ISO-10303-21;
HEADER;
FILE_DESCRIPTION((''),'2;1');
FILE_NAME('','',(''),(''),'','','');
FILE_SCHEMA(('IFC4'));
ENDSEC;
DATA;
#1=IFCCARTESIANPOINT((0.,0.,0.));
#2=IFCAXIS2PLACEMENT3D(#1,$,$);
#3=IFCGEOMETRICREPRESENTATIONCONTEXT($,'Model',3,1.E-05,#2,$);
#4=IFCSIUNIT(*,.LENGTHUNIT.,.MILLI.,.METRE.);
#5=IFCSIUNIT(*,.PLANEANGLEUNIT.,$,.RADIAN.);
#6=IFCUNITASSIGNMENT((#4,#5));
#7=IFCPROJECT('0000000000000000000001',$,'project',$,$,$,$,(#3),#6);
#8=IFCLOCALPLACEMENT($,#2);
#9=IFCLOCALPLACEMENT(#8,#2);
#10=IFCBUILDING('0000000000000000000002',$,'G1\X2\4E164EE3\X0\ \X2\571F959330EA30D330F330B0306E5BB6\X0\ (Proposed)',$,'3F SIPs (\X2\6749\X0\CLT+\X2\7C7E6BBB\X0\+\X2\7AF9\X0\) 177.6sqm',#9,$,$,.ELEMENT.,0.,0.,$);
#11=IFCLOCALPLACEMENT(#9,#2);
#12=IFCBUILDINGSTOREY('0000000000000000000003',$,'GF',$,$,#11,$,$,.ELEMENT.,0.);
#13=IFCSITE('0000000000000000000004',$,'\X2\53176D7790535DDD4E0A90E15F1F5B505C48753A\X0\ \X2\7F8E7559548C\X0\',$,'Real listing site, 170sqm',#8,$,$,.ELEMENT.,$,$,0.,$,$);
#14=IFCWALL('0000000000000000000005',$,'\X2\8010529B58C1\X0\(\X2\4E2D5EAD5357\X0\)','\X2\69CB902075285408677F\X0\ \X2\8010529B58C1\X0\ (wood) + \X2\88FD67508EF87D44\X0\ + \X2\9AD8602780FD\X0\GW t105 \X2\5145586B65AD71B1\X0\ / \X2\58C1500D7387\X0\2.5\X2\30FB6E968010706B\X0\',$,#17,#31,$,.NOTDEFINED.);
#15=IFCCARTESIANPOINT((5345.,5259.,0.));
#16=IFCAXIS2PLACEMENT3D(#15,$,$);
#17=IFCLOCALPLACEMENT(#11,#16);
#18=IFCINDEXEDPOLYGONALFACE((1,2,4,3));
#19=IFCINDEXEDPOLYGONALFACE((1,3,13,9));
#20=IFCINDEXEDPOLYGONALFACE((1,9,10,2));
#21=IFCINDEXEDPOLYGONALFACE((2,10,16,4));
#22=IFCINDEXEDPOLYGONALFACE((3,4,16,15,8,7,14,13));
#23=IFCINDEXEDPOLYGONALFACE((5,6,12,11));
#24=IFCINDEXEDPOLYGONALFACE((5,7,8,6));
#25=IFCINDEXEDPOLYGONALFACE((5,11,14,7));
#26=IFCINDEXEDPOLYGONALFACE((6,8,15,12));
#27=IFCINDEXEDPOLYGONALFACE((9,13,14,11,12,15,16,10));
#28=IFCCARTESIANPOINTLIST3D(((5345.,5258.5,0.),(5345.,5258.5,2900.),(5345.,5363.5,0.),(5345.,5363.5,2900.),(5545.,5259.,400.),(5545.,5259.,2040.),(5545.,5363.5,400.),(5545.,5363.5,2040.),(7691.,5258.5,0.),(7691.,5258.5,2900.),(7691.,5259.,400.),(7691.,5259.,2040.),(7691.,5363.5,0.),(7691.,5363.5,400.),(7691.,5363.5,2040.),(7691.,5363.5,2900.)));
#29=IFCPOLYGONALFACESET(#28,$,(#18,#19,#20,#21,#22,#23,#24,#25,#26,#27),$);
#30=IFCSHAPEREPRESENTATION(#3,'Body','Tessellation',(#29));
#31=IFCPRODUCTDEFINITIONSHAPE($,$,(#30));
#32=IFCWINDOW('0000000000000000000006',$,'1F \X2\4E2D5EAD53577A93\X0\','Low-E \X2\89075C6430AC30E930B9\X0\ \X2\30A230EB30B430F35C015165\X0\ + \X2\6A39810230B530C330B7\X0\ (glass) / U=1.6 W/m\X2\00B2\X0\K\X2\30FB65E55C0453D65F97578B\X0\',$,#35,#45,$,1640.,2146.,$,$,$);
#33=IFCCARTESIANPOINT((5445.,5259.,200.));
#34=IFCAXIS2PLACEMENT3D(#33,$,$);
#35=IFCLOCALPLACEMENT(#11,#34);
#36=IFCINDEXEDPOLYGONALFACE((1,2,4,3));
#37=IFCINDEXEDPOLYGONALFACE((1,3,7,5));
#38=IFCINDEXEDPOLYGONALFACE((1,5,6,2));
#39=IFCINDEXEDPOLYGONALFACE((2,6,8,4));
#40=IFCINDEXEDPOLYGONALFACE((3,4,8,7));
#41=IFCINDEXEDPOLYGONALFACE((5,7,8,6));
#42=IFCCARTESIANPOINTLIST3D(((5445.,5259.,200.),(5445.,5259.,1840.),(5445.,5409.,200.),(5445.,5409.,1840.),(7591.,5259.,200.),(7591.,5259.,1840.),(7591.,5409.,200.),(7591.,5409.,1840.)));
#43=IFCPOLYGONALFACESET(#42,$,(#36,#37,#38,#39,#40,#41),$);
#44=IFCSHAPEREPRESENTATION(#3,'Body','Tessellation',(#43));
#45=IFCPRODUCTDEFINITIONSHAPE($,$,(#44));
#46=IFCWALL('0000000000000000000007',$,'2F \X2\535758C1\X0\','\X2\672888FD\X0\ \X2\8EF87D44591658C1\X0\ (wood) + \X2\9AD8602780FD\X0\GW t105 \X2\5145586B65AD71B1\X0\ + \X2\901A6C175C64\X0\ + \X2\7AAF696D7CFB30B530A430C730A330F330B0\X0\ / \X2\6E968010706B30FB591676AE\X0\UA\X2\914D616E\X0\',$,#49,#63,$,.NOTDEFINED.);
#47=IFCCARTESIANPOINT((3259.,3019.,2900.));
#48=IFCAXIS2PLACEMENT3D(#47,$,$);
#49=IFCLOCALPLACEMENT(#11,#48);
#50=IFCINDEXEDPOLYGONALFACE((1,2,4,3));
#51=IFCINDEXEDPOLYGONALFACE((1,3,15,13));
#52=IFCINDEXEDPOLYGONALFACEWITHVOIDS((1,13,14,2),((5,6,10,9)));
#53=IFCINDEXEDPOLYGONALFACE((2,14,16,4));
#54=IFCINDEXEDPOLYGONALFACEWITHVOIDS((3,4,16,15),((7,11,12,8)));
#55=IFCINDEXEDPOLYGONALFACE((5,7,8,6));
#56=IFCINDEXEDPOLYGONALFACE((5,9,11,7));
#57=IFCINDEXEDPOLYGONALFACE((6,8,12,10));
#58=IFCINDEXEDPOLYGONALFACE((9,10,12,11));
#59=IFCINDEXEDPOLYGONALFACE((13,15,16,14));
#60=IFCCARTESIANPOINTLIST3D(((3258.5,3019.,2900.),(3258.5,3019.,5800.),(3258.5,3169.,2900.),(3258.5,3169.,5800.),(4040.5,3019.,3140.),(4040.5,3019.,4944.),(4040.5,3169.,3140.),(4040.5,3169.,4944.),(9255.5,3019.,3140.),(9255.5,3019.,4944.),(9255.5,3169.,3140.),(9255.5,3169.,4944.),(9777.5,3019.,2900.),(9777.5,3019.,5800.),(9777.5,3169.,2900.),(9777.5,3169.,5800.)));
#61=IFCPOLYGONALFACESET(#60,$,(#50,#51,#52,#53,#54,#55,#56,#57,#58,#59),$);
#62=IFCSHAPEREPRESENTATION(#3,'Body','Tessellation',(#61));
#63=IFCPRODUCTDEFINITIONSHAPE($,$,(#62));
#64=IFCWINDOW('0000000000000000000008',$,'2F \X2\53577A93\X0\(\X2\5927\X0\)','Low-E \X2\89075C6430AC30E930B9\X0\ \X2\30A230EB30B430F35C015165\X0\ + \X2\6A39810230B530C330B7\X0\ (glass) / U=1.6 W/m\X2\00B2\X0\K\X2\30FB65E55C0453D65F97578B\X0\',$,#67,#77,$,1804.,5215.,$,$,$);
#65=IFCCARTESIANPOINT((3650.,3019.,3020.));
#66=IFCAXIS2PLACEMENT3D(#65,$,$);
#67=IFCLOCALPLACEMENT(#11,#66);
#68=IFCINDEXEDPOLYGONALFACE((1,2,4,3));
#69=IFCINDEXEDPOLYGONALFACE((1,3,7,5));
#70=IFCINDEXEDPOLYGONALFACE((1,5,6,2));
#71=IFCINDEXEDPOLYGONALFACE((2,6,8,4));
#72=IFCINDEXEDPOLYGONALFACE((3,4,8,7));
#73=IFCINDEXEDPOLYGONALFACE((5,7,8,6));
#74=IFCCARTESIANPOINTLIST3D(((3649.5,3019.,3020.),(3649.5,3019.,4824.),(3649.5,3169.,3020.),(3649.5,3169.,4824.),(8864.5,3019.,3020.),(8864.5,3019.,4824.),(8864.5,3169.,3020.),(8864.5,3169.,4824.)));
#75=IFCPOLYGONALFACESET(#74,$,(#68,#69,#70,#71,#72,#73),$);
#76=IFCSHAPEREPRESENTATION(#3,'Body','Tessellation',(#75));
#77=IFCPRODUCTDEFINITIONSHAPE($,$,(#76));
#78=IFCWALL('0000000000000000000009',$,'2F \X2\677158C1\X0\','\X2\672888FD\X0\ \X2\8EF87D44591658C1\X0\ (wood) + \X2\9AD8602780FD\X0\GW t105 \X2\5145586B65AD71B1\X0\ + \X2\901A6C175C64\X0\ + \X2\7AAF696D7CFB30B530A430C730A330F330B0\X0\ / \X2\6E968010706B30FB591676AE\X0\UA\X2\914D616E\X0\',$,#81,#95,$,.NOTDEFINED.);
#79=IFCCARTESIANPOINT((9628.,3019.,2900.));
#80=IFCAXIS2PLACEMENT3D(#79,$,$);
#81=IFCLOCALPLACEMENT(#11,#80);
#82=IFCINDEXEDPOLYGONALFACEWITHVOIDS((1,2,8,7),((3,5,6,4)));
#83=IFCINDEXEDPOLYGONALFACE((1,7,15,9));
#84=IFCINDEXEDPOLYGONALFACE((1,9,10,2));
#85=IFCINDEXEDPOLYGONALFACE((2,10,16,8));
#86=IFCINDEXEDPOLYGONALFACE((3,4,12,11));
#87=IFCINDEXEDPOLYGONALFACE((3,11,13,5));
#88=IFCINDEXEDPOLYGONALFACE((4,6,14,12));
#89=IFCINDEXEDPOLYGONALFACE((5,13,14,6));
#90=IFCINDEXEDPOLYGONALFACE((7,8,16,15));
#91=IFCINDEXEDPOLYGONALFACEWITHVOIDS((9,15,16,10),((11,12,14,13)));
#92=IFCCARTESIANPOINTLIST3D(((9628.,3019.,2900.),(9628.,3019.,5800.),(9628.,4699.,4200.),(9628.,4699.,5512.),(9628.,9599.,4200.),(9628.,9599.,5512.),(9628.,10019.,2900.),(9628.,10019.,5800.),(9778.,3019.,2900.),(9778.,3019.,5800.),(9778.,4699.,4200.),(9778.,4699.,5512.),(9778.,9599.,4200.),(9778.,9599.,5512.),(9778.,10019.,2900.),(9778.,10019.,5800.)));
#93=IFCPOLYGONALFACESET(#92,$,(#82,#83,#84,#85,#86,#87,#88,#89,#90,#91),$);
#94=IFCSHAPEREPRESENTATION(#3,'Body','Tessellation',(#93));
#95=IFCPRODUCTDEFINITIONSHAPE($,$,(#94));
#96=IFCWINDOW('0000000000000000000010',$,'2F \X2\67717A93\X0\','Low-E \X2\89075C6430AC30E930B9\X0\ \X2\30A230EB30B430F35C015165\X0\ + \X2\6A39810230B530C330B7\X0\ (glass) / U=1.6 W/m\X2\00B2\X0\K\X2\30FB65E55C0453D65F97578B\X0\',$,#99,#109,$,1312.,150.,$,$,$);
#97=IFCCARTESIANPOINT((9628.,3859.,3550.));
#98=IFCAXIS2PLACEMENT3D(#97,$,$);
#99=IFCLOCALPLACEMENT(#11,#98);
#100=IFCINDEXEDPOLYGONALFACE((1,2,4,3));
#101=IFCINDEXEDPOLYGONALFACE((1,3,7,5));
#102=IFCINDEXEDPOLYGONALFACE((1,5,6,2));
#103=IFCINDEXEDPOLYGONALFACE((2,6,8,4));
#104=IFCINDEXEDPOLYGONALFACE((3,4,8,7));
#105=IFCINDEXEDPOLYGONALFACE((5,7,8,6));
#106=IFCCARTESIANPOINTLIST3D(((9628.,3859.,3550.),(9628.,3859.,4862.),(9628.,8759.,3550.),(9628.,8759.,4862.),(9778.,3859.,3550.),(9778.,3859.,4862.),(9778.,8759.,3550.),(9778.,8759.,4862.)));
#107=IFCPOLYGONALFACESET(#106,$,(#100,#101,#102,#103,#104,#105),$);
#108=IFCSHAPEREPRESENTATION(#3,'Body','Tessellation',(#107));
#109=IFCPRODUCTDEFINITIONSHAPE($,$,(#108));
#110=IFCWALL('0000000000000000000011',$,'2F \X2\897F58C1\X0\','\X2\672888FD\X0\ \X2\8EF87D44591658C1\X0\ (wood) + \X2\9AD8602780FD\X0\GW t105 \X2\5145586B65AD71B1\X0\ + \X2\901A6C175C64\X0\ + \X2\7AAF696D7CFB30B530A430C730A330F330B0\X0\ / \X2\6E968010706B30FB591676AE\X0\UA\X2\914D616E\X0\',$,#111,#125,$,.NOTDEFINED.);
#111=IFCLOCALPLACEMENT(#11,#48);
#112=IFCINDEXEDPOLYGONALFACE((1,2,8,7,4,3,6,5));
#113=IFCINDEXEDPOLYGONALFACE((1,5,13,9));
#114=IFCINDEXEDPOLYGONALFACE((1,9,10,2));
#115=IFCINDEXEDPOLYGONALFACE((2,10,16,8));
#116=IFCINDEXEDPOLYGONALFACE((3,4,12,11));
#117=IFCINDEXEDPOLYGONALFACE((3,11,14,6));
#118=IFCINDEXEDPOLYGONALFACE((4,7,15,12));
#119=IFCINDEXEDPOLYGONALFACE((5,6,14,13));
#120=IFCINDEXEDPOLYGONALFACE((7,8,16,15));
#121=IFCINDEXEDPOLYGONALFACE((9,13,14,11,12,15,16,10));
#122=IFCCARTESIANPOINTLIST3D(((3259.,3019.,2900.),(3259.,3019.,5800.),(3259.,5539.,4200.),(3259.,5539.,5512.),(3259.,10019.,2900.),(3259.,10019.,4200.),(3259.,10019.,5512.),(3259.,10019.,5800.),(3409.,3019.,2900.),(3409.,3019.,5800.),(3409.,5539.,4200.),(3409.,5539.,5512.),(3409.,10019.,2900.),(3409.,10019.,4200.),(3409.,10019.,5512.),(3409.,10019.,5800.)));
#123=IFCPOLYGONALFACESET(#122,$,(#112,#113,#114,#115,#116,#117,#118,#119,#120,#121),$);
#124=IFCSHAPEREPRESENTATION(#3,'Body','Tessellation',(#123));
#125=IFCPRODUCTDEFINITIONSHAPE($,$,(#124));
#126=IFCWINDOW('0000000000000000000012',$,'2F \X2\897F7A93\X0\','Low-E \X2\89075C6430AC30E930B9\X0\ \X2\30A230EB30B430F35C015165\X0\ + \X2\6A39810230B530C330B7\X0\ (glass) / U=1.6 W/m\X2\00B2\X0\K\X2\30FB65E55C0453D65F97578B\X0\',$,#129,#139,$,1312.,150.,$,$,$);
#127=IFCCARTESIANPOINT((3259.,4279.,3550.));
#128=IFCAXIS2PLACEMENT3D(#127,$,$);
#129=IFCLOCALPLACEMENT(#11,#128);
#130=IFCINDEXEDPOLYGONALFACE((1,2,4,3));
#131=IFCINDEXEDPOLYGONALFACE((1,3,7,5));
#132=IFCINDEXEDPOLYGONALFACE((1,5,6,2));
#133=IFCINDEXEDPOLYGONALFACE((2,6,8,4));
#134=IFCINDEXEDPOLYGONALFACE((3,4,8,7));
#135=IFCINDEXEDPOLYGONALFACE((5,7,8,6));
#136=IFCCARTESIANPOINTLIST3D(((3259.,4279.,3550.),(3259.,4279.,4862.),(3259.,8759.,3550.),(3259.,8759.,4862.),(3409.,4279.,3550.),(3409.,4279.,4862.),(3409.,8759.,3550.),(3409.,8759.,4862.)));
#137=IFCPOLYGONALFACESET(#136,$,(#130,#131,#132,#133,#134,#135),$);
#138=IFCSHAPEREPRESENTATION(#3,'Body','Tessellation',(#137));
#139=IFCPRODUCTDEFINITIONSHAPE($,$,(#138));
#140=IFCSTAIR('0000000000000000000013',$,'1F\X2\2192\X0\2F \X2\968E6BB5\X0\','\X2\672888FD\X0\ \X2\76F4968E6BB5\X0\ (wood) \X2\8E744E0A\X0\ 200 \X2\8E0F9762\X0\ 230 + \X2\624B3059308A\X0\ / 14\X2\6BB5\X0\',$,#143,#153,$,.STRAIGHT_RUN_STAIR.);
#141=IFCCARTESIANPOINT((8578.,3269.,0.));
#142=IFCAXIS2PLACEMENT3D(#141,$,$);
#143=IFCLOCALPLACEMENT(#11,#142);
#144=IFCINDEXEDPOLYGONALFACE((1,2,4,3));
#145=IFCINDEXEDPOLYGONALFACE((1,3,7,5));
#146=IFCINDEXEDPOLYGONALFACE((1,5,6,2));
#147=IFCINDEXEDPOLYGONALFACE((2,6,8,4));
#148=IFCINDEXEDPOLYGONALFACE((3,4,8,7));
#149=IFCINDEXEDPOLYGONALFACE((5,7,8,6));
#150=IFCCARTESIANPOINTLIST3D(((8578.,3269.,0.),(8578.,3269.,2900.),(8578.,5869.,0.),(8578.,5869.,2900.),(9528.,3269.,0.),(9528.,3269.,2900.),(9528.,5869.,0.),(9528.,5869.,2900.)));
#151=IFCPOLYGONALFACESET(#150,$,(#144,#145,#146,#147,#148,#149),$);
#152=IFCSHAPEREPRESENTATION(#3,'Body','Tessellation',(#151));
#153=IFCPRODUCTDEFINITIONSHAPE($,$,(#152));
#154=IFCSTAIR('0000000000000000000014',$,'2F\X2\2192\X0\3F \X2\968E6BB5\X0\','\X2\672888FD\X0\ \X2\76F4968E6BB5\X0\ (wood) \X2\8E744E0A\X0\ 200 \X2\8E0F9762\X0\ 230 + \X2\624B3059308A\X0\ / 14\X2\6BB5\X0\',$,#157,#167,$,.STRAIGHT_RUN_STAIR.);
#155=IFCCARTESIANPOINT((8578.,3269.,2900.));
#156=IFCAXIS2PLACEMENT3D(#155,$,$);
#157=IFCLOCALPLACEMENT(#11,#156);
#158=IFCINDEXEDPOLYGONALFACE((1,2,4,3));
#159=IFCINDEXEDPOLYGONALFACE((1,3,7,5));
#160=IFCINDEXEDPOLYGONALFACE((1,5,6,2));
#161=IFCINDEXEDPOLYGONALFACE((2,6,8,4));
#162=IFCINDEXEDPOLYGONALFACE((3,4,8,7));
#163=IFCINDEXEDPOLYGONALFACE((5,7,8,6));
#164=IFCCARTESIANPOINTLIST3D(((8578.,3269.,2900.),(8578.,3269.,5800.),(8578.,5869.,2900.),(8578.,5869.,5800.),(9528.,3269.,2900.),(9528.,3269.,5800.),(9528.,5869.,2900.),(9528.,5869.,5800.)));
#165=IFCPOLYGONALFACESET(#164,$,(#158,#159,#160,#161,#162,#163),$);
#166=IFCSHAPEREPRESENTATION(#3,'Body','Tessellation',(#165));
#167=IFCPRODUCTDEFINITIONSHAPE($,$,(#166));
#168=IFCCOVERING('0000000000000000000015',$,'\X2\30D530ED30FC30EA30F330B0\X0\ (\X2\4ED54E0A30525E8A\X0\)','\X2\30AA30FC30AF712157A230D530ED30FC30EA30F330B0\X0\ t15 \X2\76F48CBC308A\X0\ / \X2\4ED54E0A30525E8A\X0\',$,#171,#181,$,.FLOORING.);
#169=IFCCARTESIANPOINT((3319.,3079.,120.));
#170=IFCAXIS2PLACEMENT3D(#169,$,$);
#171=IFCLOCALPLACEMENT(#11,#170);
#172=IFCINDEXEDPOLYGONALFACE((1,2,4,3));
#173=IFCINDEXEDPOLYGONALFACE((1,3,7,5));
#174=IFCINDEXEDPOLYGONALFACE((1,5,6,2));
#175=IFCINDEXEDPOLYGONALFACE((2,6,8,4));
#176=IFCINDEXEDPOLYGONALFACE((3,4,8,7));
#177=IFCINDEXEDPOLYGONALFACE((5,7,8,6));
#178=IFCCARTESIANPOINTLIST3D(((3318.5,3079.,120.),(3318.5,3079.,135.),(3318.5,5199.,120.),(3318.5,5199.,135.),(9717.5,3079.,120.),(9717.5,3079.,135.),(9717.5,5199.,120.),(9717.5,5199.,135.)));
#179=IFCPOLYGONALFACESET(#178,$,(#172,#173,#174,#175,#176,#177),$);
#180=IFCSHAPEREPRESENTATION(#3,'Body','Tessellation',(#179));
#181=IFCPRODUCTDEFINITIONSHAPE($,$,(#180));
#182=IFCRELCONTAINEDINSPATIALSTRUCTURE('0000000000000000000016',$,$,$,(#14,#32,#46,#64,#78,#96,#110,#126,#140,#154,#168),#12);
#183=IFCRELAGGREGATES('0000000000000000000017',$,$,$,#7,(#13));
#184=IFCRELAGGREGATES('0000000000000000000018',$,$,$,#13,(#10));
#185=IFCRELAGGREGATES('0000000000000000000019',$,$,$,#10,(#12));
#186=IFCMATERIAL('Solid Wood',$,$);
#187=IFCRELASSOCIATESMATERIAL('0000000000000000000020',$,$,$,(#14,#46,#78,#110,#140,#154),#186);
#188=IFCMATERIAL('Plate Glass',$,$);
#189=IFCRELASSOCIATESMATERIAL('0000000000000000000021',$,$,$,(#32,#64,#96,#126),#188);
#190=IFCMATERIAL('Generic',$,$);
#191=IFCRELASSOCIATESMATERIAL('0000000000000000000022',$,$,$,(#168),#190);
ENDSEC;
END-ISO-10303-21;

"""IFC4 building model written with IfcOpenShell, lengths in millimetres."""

from ifc_helpers import new_model, si_unit, frame, frame_2d, origin, place, context, project, spatial, rectangle, extrude, material, element, fill, save


model = new_model("IFC4")

# Units and contexts
model_context = context("Model", 3, precision=1e-05, world=origin())
ifc_project = project(units=[si_unit("LENGTHUNIT", "METRE", prefix="MILLI"), si_unit("PLANEANGLEUNIT", "RADIAN")], contexts=[model_context])

# Site, building, storey
site_placement = place(None, origin())
site = spatial("IfcSite", under=ifc_project, at=site_placement, Name="北海道川上郡弟子屈町 美留和", ObjectType="Real listing site, 170sqm", CompositionType="ELEMENT", RefElevation=0.0)
building_placement = place(site_placement, origin())
building = spatial("IfcBuilding", under=site, at=building_placement, Name="G1世代 土間リビングの家 (Proposed)", ObjectType="3F SIPs (杉CLT+籾殻+竹) 177.6sqm", CompositionType="ELEMENT", ElevationOfRefHeight=0.0, ElevationOfTerrain=0.0)
storey_placement = place(building_placement, origin())
storey = spatial("IfcBuildingStorey", under=building, at=storey_placement, Name="GF", CompositionType="ELEMENT", Elevation=0.0)

# Shared definitions
ifc_material_1 = material(Name="Solid Wood")
ifc_material_2 = material(Name="Generic")

# Shared definitions
ifc_material_3 = material(Name="Plate Glass")

# Walls, openings, windows
wall_1_placement = place(storey_placement, frame((5345.0, 5259.0, 0.0)))
wall_1 = element("IfcWall", 1, at=wall_1_placement, inside=storey, material=ifc_material_1, Name="耐力壁(中庭南)", Description="構造用合板 耐力壁 (wood) + 製材軸組 + 高性能GW t105 充填断熱 / 壁倍率2.5・準耐火", PredefinedType="NOTDEFINED", context=model_context, shape_type="SweptSolid", body=[
    extrude(rectangle(XDim=2346.0, YDim=105.0, at=frame_2d((1173.0, 52.0))), frame((5345.0, 5259.0, 0.0)), (0.0, 0.0, 1.0), 2900.0),
])
opening_1_placement = place(storey_placement, frame((5445.0, 5259.0, 200.0)))
opening_1 = element("IfcOpeningElement", 2, at=opening_1_placement, cuts=wall_1, PredefinedType="NOTDEFINED", context=model_context, shape_type="SweptSolid", body=[
    extrude(rectangle(XDim=2146.0, YDim=150.0, at=frame_2d((1073.0, 75.0))), frame((5445.0, 5259.0, 200.0)), (0.0, 0.0, 1.0), 1640.0),
])
window_1_placement = place(storey_placement, frame((5445.0, 5259.0, 200.0)))
window_1 = element("IfcWindow", 3, at=window_1_placement, inside=storey, material=ifc_material_3, Name="1F 中庭南窓", Description="Low-E 複層ガラス アルゴン封入 + 樹脂サッシ (glass) / U=1.6 W/m²K・日射取得型", OverallHeight=1640.0, OverallWidth=2146.0, context=model_context, shape_type="SweptSolid", body=[
    extrude(rectangle(XDim=2146.0, YDim=150.0, at=frame_2d((1073.0, 75.0))), frame((5445.0, 5259.0, 200.0)), (0.0, 0.0, 1.0), 1640.0),
])
fill(opening_1, window_1)
wall_2_placement = place(storey_placement, frame((3259.0, 3019.0, 2900.0)))
wall_2 = element("IfcWall", 4, at=wall_2_placement, inside=storey, material=ifc_material_1, Name="2F 南壁", Description="木製 軸組外壁 (wood) + 高性能GW t105 充填断熱 + 通気層 + 窯業系サイディング / 準耐火・外皮UA配慮", PredefinedType="NOTDEFINED", context=model_context, shape_type="SweptSolid", body=[
    extrude(rectangle(XDim=6519.0, YDim=150.0, at=frame_2d((3259.0, 75.0))), frame((3259.0, 3019.0, 2900.0)), (0.0, 0.0, 1.0), 2900.0),
])
opening_2_placement = place(storey_placement, frame((3650.0, 3019.0, 3020.0)))
opening_2 = element("IfcOpeningElement", 5, at=opening_2_placement, cuts=wall_2, PredefinedType="NOTDEFINED", context=model_context, shape_type="SweptSolid", body=[
    extrude(rectangle(XDim=5215.0, YDim=150.0, at=frame_2d((2607.0, 75.0))), frame((3650.0, 3019.0, 3020.0)), (0.0, 0.0, 1.0), 1804.0),
])
window_2_placement = place(storey_placement, frame((3650.0, 3019.0, 3020.0)))
window_2 = element("IfcWindow", 6, at=window_2_placement, inside=storey, material=ifc_material_3, Name="2F 南窓(大)", Description="Low-E 複層ガラス アルゴン封入 + 樹脂サッシ (glass) / U=1.6 W/m²K・日射取得型", OverallHeight=1804.0, OverallWidth=5215.0, context=model_context, shape_type="SweptSolid", body=[
    extrude(rectangle(XDim=5215.0, YDim=150.0, at=frame_2d((2607.0, 75.0))), frame((3650.0, 3019.0, 3020.0)), (0.0, 0.0, 1.0), 1804.0),
])
fill(opening_2, window_2)
wall_3_placement = place(storey_placement, frame((9628.0, 3019.0, 2900.0)))
wall_3 = element("IfcWall", 7, at=wall_3_placement, inside=storey, material=ifc_material_1, Name="2F 東壁", Description="木製 軸組外壁 (wood) + 高性能GW t105 充填断熱 + 通気層 + 窯業系サイディング / 準耐火・外皮UA配慮", PredefinedType="NOTDEFINED", context=model_context, shape_type="SweptSolid", body=[
    extrude(rectangle(XDim=150.0, YDim=7000.0, at=frame_2d((75.0, 3500.0))), frame((9628.0, 3019.0, 2900.0)), (0.0, 0.0, 1.0), 2900.0),
])
opening_3_placement = place(storey_placement, frame((9628.0, 3859.0, 3550.0)))
opening_3 = element("IfcOpeningElement", 8, at=opening_3_placement, cuts=wall_3, PredefinedType="NOTDEFINED", context=model_context, shape_type="SweptSolid", body=[
    extrude(rectangle(XDim=150.0, YDim=4900.0, at=frame_2d((75.0, 2450.0))), frame((9628.0, 3859.0, 3550.0)), (0.0, 0.0, 1.0), 1312.0),
])
window_3_placement = place(storey_placement, frame((9628.0, 3859.0, 3550.0)))
window_3 = element("IfcWindow", 9, at=window_3_placement, inside=storey, material=ifc_material_3, Name="2F 東窓", Description="Low-E 複層ガラス アルゴン封入 + 樹脂サッシ (glass) / U=1.6 W/m²K・日射取得型", OverallHeight=1312.0, OverallWidth=150.0, context=model_context, shape_type="SweptSolid", body=[
    extrude(rectangle(XDim=150.0, YDim=4900.0, at=frame_2d((75.0, 2450.0))), frame((9628.0, 3859.0, 3550.0)), (0.0, 0.0, 1.0), 1312.0),
])
fill(opening_3, window_3)
wall_4_placement = place(storey_placement, frame((3259.0, 3019.0, 2900.0)))
wall_4 = element("IfcWall", 10, at=wall_4_placement, inside=storey, material=ifc_material_1, Name="2F 西壁", Description="木製 軸組外壁 (wood) + 高性能GW t105 充填断熱 + 通気層 + 窯業系サイディング / 準耐火・外皮UA配慮", PredefinedType="NOTDEFINED", context=model_context, shape_type="SweptSolid", body=[
    extrude(rectangle(XDim=150.0, YDim=7000.0, at=frame_2d((75.0, 3500.0))), frame((3259.0, 3019.0, 2900.0)), (0.0, 0.0, 1.0), 2900.0),
])
opening_4_placement = place(storey_placement, frame((3259.0, 4279.0, 3550.0)))
opening_4 = element("IfcOpeningElement", 11, at=opening_4_placement, cuts=wall_4, PredefinedType="NOTDEFINED", context=model_context, shape_type="SweptSolid", body=[
    extrude(rectangle(XDim=150.0, YDim=4480.0, at=frame_2d((75.0, 2240.0))), frame((3259.0, 4279.0, 3550.0)), (0.0, 0.0, 1.0), 1312.0),
])
window_4_placement = place(storey_placement, frame((3259.0, 4279.0, 3550.0)))
window_4 = element("IfcWindow", 12, at=window_4_placement, inside=storey, material=ifc_material_3, Name="2F 西窓", Description="Low-E 複層ガラス アルゴン封入 + 樹脂サッシ (glass) / U=1.6 W/m²K・日射取得型", OverallHeight=1312.0, OverallWidth=150.0, context=model_context, shape_type="SweptSolid", body=[
    extrude(rectangle(XDim=150.0, YDim=4480.0, at=frame_2d((75.0, 2240.0))), frame((3259.0, 4279.0, 3550.0)), (0.0, 0.0, 1.0), 1312.0),
])
fill(opening_4, window_4)

# Stairs
stair_1_placement = place(storey_placement, frame((8578.0, 3269.0, 0.0)))
element("IfcStair", 13, at=stair_1_placement, inside=storey, material=ifc_material_1, Name="1F→2F 階段", Description="木製 直階段 (wood) 蹴上 200 踏面 230 + 手すり / 14段", PredefinedType="STRAIGHT_RUN_STAIR", context=model_context, shape_type="SweptSolid", body=[
    extrude(rectangle(XDim=950.0, YDim=2600.0, at=frame_2d((475.0, 1300.0))), frame((8578.0, 3269.0, 0.0)), (0.0, 0.0, 1.0), 2900.0),
])
stair_2_placement = place(storey_placement, frame((8578.0, 3269.0, 2900.0)))
element("IfcStair", 14, at=stair_2_placement, inside=storey, material=ifc_material_1, Name="2F→3F 階段", Description="木製 直階段 (wood) 蹴上 200 踏面 230 + 手すり / 14段", PredefinedType="STRAIGHT_RUN_STAIR", context=model_context, shape_type="SweptSolid", body=[
    extrude(rectangle(XDim=950.0, YDim=2600.0, at=frame_2d((475.0, 1300.0))), frame((8578.0, 3269.0, 2900.0)), (0.0, 0.0, 1.0), 2900.0),
])

# Covering
covering_placement = place(storey_placement, frame((3319.0, 3079.0, 120.0)))
element("IfcCovering", 15, at=covering_placement, inside=storey, material=ifc_material_2, Name="フローリング (仕上げ床)", Description="オーク無垢フローリング t15 直貼り / 仕上げ床", PredefinedType="FLOORING", context=model_context, shape_type="SweptSolid", body=[
    extrude(rectangle(XDim=6399.0, YDim=2120.0, at=frame_2d((3199.0, 1060.0))), frame((3319.0, 3079.0, 120.0)), (0.0, 0.0, 1.0), 15.0),
])

save(model, "model.ifc")
